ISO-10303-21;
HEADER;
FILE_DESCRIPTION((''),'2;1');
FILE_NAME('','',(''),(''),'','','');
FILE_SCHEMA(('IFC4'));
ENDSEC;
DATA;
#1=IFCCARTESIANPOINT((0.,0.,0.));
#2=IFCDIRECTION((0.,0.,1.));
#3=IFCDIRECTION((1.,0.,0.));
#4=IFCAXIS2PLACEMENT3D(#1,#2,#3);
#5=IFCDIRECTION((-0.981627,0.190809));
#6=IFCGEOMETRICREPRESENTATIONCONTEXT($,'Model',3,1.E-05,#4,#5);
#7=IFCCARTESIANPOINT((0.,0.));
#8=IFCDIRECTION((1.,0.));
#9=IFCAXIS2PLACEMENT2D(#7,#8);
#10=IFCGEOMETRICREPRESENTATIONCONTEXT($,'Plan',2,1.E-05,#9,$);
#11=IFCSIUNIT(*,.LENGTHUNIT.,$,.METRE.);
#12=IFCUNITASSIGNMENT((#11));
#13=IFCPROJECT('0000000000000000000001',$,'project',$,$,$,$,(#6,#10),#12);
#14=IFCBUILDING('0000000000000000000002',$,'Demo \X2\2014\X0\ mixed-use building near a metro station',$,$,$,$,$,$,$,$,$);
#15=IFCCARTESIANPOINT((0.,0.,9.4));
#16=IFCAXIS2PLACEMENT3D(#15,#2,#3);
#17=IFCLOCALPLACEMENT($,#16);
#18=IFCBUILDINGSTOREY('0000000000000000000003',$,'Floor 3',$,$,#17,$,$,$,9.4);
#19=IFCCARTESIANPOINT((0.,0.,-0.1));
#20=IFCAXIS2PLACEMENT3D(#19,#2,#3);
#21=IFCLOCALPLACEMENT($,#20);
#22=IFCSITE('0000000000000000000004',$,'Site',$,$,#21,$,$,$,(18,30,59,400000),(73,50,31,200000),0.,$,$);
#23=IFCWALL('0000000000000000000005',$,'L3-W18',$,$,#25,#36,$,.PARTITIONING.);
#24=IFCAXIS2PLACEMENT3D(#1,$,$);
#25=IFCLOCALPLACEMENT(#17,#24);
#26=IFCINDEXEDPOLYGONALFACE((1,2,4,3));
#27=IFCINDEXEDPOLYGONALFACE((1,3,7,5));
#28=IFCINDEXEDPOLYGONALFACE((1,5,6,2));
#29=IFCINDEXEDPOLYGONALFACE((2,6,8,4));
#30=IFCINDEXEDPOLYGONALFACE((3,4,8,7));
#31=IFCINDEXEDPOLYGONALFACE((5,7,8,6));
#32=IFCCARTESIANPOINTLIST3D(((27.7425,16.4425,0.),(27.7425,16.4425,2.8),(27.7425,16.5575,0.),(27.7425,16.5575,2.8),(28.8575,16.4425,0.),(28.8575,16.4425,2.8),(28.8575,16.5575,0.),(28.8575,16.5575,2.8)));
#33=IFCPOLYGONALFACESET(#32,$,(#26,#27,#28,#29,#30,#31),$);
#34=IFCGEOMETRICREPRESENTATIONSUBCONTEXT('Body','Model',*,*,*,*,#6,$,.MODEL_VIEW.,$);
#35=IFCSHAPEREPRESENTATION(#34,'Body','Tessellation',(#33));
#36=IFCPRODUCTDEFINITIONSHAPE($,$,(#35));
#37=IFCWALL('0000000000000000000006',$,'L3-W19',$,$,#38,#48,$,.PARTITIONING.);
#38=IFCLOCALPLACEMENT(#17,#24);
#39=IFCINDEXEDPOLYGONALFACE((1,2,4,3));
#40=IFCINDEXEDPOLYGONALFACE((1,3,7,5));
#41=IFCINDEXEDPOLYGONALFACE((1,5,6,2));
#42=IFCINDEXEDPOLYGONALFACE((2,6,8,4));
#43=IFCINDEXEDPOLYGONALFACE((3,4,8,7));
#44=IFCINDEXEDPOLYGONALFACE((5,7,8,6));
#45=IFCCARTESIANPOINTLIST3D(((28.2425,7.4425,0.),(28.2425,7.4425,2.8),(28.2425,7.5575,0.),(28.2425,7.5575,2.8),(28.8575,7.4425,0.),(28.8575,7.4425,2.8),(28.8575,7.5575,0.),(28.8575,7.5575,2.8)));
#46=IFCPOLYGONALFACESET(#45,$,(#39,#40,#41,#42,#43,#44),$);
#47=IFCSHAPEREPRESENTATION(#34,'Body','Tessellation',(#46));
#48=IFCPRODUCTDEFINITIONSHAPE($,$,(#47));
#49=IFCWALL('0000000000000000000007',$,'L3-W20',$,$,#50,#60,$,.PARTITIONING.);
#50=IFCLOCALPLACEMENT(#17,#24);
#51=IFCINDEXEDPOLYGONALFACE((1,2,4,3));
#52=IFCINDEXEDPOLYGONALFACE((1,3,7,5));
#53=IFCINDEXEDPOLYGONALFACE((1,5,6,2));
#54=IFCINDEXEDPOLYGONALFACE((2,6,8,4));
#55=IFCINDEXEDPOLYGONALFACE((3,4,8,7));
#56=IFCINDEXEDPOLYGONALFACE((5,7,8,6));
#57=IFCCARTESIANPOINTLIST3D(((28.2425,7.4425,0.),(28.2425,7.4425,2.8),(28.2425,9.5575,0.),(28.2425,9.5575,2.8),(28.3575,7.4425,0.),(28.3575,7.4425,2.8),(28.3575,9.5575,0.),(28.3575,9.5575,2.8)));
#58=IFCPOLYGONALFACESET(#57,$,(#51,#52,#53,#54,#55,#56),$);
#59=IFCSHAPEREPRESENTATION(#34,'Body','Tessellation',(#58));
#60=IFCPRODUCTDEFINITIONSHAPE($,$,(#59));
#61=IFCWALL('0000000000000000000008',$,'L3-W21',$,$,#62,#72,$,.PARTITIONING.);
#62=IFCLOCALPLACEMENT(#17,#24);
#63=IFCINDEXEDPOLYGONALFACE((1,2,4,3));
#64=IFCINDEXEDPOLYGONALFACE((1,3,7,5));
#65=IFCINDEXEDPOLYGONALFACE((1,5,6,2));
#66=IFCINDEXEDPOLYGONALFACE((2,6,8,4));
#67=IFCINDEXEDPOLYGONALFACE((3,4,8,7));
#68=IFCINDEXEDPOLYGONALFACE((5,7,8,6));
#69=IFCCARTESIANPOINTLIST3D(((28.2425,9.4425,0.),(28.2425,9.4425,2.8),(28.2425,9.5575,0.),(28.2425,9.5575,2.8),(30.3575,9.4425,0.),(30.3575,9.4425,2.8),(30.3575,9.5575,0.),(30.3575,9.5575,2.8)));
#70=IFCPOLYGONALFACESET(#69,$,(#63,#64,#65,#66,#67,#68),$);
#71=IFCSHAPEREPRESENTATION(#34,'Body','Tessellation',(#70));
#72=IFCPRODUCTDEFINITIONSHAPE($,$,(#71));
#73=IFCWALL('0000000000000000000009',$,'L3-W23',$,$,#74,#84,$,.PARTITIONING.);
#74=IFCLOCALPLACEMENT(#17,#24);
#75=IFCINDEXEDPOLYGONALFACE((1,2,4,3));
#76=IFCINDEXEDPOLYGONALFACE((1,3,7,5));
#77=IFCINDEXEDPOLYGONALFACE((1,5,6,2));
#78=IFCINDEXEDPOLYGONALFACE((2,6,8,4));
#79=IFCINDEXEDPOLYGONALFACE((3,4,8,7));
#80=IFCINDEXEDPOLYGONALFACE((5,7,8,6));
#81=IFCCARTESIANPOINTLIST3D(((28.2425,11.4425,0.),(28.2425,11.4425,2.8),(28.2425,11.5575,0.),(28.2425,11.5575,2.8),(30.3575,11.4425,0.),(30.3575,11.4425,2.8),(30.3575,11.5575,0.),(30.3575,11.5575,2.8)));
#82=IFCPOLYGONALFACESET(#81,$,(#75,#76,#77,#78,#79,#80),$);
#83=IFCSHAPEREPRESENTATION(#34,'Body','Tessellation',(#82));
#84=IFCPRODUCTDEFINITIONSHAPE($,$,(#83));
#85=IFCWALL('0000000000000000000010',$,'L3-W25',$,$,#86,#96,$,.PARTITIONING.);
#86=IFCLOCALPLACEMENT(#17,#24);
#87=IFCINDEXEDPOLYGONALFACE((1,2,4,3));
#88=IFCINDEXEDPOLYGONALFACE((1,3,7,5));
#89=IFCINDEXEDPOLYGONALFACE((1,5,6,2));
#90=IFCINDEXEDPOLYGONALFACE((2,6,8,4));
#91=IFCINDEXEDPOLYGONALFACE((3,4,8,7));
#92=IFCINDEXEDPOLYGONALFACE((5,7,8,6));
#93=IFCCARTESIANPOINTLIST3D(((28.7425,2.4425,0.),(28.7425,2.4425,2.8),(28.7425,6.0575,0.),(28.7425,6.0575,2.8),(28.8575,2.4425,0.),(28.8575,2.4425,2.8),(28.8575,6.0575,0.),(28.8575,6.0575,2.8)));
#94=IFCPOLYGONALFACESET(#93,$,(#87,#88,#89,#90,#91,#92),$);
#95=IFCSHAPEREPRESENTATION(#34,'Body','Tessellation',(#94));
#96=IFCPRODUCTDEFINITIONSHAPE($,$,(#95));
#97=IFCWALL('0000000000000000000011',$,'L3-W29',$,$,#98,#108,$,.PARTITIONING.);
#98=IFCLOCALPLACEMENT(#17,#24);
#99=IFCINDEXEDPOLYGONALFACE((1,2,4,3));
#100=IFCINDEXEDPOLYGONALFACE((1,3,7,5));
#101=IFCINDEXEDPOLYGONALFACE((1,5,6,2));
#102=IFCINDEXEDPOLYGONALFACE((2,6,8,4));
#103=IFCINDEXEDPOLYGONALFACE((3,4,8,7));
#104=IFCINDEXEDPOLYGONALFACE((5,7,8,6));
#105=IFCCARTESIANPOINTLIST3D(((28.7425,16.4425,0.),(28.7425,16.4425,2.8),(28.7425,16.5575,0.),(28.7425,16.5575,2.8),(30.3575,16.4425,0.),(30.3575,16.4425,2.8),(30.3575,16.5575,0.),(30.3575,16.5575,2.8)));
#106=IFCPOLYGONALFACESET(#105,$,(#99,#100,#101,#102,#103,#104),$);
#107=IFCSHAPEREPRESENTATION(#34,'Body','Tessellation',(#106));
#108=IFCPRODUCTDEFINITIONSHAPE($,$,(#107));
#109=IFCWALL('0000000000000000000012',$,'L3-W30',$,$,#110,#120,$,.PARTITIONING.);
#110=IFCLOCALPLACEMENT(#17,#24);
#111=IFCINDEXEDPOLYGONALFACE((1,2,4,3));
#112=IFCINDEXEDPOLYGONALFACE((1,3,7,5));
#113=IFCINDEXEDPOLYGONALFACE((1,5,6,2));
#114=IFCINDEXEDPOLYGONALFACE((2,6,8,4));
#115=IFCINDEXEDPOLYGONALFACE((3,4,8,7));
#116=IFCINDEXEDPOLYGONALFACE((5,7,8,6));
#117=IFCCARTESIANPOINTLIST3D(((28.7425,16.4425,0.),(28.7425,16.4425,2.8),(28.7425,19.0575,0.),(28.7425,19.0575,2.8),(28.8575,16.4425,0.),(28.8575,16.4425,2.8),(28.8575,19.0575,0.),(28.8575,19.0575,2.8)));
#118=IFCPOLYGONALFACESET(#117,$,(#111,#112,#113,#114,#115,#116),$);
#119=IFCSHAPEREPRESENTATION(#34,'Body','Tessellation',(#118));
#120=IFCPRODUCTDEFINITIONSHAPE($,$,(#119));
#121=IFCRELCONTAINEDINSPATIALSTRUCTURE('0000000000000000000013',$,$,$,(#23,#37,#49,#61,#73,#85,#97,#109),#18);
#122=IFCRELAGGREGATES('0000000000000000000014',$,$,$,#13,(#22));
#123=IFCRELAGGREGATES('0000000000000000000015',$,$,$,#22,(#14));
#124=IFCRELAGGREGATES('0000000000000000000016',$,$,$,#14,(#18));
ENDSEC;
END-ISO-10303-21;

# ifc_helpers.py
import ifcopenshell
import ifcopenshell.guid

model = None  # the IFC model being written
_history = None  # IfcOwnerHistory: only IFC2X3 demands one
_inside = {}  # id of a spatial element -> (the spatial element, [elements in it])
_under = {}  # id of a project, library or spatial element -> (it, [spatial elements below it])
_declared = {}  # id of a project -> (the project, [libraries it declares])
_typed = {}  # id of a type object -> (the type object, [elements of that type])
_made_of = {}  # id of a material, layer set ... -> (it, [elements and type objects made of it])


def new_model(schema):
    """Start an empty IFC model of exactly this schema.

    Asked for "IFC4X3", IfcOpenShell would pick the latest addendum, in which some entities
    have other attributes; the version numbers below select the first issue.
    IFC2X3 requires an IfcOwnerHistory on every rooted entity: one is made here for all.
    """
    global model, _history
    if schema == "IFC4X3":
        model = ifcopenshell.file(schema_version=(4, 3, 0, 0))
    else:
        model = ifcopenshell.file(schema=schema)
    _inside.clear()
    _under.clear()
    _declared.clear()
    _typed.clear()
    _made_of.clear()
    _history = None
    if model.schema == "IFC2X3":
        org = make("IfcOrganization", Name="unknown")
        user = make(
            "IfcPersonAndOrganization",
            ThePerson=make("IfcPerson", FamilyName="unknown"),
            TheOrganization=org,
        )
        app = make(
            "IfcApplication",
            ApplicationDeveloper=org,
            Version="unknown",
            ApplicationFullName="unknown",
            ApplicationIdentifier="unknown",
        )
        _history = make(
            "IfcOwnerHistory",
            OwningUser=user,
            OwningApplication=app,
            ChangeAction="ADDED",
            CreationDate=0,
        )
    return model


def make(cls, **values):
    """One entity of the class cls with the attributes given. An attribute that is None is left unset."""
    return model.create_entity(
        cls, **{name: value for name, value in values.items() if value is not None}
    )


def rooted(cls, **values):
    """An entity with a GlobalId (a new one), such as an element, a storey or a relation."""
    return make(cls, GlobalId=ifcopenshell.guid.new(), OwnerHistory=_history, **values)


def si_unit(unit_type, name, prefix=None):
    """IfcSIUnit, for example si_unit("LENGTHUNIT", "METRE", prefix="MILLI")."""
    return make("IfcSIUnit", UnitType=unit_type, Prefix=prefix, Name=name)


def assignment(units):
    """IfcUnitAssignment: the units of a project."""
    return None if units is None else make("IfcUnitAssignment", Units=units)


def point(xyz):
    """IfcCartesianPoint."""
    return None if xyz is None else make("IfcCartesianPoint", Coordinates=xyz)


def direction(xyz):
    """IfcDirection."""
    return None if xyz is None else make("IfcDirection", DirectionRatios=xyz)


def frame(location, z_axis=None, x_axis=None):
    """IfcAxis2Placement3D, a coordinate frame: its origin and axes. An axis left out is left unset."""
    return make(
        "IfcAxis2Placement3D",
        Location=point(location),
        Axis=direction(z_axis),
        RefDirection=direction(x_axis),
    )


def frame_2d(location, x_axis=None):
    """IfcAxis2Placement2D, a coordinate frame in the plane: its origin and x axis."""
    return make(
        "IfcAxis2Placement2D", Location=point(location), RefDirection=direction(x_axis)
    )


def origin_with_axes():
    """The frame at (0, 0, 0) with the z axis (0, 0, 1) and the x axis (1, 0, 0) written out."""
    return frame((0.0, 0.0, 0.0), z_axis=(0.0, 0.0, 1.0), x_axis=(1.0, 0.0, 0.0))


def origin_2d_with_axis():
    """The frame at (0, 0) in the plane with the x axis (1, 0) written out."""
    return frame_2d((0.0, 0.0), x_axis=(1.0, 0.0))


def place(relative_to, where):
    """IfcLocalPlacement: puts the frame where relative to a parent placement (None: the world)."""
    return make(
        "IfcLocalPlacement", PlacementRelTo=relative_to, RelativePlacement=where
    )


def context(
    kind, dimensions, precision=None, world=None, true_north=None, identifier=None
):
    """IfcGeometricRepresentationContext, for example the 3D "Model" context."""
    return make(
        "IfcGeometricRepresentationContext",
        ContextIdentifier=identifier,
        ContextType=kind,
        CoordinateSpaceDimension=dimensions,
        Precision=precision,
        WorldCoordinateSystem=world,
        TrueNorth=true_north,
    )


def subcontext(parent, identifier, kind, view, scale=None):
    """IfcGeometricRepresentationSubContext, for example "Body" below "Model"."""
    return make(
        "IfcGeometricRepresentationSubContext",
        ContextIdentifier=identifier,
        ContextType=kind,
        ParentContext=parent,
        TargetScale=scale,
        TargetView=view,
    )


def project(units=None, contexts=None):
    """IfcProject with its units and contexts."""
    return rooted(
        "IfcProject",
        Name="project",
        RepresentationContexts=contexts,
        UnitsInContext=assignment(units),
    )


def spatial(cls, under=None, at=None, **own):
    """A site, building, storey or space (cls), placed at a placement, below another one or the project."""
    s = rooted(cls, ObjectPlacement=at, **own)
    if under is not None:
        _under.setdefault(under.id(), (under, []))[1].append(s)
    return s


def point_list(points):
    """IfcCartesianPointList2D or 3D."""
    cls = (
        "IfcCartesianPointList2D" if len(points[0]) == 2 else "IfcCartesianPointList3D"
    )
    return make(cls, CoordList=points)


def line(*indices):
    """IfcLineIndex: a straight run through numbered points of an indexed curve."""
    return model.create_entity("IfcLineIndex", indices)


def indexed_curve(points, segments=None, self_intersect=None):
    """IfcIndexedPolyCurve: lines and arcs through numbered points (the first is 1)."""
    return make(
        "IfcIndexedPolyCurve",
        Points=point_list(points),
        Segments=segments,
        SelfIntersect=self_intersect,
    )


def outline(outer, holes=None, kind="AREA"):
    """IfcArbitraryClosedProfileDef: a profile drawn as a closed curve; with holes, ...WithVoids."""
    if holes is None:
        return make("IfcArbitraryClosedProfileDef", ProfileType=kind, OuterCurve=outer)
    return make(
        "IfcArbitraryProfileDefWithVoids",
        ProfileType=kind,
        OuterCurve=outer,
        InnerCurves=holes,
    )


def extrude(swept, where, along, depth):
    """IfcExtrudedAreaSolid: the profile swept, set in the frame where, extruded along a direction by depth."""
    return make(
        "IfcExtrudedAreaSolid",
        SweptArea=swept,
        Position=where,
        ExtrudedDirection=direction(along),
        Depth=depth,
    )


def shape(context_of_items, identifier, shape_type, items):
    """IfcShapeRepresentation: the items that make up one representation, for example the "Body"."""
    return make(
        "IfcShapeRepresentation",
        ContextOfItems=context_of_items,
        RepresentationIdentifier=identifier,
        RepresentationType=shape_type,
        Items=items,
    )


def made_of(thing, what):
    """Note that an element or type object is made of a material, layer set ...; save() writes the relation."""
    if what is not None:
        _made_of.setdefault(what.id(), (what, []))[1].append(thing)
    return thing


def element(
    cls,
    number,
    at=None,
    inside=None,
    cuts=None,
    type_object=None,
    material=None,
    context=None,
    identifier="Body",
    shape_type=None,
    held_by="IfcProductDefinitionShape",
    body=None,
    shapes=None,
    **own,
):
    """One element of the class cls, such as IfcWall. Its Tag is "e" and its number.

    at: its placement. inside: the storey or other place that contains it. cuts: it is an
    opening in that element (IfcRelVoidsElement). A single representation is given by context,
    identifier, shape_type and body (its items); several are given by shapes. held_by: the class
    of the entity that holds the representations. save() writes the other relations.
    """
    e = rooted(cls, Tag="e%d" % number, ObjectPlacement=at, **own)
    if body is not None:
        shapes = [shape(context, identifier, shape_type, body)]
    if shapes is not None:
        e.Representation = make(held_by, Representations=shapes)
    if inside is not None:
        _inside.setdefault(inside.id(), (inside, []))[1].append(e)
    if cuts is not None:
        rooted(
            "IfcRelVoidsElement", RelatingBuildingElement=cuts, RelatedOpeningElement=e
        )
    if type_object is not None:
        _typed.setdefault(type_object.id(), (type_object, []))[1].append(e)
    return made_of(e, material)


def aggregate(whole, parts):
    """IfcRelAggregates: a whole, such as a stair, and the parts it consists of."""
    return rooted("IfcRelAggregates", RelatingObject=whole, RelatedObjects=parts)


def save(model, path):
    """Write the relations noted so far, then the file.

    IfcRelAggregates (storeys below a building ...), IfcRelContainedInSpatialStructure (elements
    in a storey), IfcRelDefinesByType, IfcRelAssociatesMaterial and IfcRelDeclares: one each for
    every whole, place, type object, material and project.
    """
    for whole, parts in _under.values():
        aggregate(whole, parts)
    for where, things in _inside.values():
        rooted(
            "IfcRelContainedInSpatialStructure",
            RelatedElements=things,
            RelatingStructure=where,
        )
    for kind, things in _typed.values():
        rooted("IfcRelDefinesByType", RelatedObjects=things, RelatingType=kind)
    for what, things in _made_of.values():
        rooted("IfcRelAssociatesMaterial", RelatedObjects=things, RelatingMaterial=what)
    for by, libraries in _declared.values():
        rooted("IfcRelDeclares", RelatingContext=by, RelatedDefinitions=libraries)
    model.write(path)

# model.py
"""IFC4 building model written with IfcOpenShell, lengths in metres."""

from ifc_helpers import new_model, si_unit, direction, frame, origin_with_axes, origin_2d_with_axis, place, context, subcontext, project, spatial, line, indexed_curve, outline, extrude, element, save


model = new_model("IFC4")

# Units and contexts
model_context = context("Model", 3, precision=1e-05, world=origin_with_axes(), true_north=direction((-0.981627, 0.190809)))
plan_context = context("Plan", 2, precision=1e-05, world=origin_2d_with_axis())
body_context = subcontext(model_context, "Body", "Model", "MODEL_VIEW")
ifc_project = project(units=[si_unit("LENGTHUNIT", "METRE")], contexts=[model_context, plan_context])

# Site, building, storey
site_placement = place(None, frame((0.0, 0.0, -0.1), z_axis=(0.0, 0.0, 1.0), x_axis=(1.0, 0.0, 0.0)))
site = spatial("IfcSite", under=ifc_project, at=site_placement, Name="Site", RefLatitude=(18, 30, 59, 400000), RefLongitude=(73, 50, 31, 200000), RefElevation=0.0)
building = spatial("IfcBuilding", under=site, Name="Demo — mixed-use building near a metro station")
storey_placement = place(None, frame((0.0, 0.0, 9.4), z_axis=(0.0, 0.0, 1.0), x_axis=(1.0, 0.0, 0.0)))
storey = spatial("IfcBuildingStorey", under=building, at=storey_placement, Name="Floor 3", Elevation=9.4)

# Walls
wall_1_placement = place(storey_placement, frame((0.0, 0.0, -9.4), z_axis=(0.0, 0.0, 1.0), x_axis=(1.0, 0.0, 0.0)))
element("IfcWall", 1, at=wall_1_placement, inside=storey, Name="L3-W18", PredefinedType="PARTITIONING", context=body_context, shape_type="SweptSolid", body=[
    extrude(outline(indexed_curve([(28.8575, 16.4425), (27.7425, 16.4425), (27.7425, 16.5575), (28.8575, 16.5575)], segments=[line(1, 2, 3, 4, 1)])), frame((0.0, 0.0, 9.4), z_axis=(0.0, 0.0, 1.0), x_axis=(1.0, 0.0, 0.0)), (0.0, 0.0, 1.0), 2.8),
])
wall_2_placement = place(storey_placement, frame((0.0, 0.0, -9.4), z_axis=(0.0, 0.0, 1.0), x_axis=(1.0, 0.0, 0.0)))
element("IfcWall", 2, at=wall_2_placement, inside=storey, Name="L3-W19", PredefinedType="PARTITIONING", context=body_context, shape_type="SweptSolid", body=[
    extrude(outline(indexed_curve([(28.8575, 7.4425), (28.2425, 7.4425), (28.2425, 7.5575), (28.8575, 7.5575)], segments=[line(1, 2, 3, 4, 1)])), frame((0.0, 0.0, 9.4), z_axis=(0.0, 0.0, 1.0), x_axis=(1.0, 0.0, 0.0)), (0.0, 0.0, 1.0), 2.8),
])
wall_3_placement = place(storey_placement, frame((0.0, 0.0, -9.4), z_axis=(0.0, 0.0, 1.0), x_axis=(1.0, 0.0, 0.0)))
element("IfcWall", 3, at=wall_3_placement, inside=storey, Name="L3-W20", PredefinedType="PARTITIONING", context=body_context, shape_type="SweptSolid", body=[
    extrude(outline(indexed_curve([(28.2425, 7.4425), (28.2425, 9.5575), (28.3575, 9.5575), (28.3575, 7.4425)], segments=[line(1, 2, 3, 4, 1)])), frame((0.0, 0.0, 9.4), z_axis=(0.0, 0.0, 1.0), x_axis=(1.0, 0.0, 0.0)), (0.0, 0.0, 1.0), 2.8),
])
wall_4_placement = place(storey_placement, frame((0.0, 0.0, -9.4), z_axis=(0.0, 0.0, 1.0), x_axis=(1.0, 0.0, 0.0)))
element("IfcWall", 4, at=wall_4_placement, inside=storey, Name="L3-W21", PredefinedType="PARTITIONING", context=body_context, shape_type="SweptSolid", body=[
    extrude(outline(indexed_curve([(30.3575, 9.4425), (28.2425, 9.4425), (28.2425, 9.5575), (30.3575, 9.5575)], segments=[line(1, 2, 3, 4, 1)])), frame((0.0, 0.0, 9.4), z_axis=(0.0, 0.0, 1.0), x_axis=(1.0, 0.0, 0.0)), (0.0, 0.0, 1.0), 2.8),
])

# Wall
wall_5_placement = place(storey_placement, frame((0.0, 0.0, -9.4), z_axis=(0.0, 0.0, 1.0), x_axis=(1.0, 0.0, 0.0)))
element("IfcWall", 5, at=wall_5_placement, inside=storey, Name="L3-W23", PredefinedType="PARTITIONING", context=body_context, shape_type="SweptSolid", body=[
    extrude(outline(indexed_curve([(28.2425, 11.5575), (30.3575, 11.5575), (30.3575, 11.4425), (28.2425, 11.4425)], segments=[line(1, 2, 3, 4, 1)])), frame((0.0, 0.0, 9.4), z_axis=(0.0, 0.0, 1.0), x_axis=(1.0, 0.0, 0.0)), (0.0, 0.0, 1.0), 2.8),
])

# Wall
wall_6_placement = place(storey_placement, frame((0.0, 0.0, -9.4), z_axis=(0.0, 0.0, 1.0), x_axis=(1.0, 0.0, 0.0)))
element("IfcWall", 6, at=wall_6_placement, inside=storey, Name="L3-W25", PredefinedType="PARTITIONING", context=body_context, shape_type="SweptSolid", body=[
    extrude(outline(indexed_curve([(28.7425, 2.4425), (28.7425, 6.0575), (28.8575, 6.0575), (28.8575, 2.4425)], segments=[line(1, 2, 3, 4, 1)])), frame((0.0, 0.0, 9.4), z_axis=(0.0, 0.0, 1.0), x_axis=(1.0, 0.0, 0.0)), (0.0, 0.0, 1.0), 2.8),
])

# Walls
wall_7_placement = place(storey_placement, frame((0.0, 0.0, -9.4), z_axis=(0.0, 0.0, 1.0), x_axis=(1.0, 0.0, 0.0)))
element("IfcWall", 7, at=wall_7_placement, inside=storey, Name="L3-W29", PredefinedType="PARTITIONING", context=body_context, shape_type="SweptSolid", body=[
    extrude(outline(indexed_curve([(30.3575, 16.4425), (28.7425, 16.4425), (28.7425, 16.5575), (30.3575, 16.5575)], segments=[line(1, 2, 3, 4, 1)])), frame((0.0, 0.0, 9.4), z_axis=(0.0, 0.0, 1.0), x_axis=(1.0, 0.0, 0.0)), (0.0, 0.0, 1.0), 2.8),
])
wall_8_placement = place(storey_placement, frame((0.0, 0.0, -9.4), z_axis=(0.0, 0.0, 1.0), x_axis=(1.0, 0.0, 0.0)))
element("IfcWall", 8, at=wall_8_placement, inside=storey, Name="L3-W30", PredefinedType="PARTITIONING", context=body_context, shape_type="SweptSolid", body=[
    extrude(outline(indexed_curve([(28.7425, 16.4425), (28.7425, 19.0575), (28.8575, 19.0575), (28.8575, 16.4425)], segments=[line(1, 2, 3, 4, 1)])), frame((0.0, 0.0, 9.4), z_axis=(0.0, 0.0, 1.0), x_axis=(1.0, 0.0, 0.0)), (0.0, 0.0, 1.0), 2.8),
])

save(model, "model.ifc")
